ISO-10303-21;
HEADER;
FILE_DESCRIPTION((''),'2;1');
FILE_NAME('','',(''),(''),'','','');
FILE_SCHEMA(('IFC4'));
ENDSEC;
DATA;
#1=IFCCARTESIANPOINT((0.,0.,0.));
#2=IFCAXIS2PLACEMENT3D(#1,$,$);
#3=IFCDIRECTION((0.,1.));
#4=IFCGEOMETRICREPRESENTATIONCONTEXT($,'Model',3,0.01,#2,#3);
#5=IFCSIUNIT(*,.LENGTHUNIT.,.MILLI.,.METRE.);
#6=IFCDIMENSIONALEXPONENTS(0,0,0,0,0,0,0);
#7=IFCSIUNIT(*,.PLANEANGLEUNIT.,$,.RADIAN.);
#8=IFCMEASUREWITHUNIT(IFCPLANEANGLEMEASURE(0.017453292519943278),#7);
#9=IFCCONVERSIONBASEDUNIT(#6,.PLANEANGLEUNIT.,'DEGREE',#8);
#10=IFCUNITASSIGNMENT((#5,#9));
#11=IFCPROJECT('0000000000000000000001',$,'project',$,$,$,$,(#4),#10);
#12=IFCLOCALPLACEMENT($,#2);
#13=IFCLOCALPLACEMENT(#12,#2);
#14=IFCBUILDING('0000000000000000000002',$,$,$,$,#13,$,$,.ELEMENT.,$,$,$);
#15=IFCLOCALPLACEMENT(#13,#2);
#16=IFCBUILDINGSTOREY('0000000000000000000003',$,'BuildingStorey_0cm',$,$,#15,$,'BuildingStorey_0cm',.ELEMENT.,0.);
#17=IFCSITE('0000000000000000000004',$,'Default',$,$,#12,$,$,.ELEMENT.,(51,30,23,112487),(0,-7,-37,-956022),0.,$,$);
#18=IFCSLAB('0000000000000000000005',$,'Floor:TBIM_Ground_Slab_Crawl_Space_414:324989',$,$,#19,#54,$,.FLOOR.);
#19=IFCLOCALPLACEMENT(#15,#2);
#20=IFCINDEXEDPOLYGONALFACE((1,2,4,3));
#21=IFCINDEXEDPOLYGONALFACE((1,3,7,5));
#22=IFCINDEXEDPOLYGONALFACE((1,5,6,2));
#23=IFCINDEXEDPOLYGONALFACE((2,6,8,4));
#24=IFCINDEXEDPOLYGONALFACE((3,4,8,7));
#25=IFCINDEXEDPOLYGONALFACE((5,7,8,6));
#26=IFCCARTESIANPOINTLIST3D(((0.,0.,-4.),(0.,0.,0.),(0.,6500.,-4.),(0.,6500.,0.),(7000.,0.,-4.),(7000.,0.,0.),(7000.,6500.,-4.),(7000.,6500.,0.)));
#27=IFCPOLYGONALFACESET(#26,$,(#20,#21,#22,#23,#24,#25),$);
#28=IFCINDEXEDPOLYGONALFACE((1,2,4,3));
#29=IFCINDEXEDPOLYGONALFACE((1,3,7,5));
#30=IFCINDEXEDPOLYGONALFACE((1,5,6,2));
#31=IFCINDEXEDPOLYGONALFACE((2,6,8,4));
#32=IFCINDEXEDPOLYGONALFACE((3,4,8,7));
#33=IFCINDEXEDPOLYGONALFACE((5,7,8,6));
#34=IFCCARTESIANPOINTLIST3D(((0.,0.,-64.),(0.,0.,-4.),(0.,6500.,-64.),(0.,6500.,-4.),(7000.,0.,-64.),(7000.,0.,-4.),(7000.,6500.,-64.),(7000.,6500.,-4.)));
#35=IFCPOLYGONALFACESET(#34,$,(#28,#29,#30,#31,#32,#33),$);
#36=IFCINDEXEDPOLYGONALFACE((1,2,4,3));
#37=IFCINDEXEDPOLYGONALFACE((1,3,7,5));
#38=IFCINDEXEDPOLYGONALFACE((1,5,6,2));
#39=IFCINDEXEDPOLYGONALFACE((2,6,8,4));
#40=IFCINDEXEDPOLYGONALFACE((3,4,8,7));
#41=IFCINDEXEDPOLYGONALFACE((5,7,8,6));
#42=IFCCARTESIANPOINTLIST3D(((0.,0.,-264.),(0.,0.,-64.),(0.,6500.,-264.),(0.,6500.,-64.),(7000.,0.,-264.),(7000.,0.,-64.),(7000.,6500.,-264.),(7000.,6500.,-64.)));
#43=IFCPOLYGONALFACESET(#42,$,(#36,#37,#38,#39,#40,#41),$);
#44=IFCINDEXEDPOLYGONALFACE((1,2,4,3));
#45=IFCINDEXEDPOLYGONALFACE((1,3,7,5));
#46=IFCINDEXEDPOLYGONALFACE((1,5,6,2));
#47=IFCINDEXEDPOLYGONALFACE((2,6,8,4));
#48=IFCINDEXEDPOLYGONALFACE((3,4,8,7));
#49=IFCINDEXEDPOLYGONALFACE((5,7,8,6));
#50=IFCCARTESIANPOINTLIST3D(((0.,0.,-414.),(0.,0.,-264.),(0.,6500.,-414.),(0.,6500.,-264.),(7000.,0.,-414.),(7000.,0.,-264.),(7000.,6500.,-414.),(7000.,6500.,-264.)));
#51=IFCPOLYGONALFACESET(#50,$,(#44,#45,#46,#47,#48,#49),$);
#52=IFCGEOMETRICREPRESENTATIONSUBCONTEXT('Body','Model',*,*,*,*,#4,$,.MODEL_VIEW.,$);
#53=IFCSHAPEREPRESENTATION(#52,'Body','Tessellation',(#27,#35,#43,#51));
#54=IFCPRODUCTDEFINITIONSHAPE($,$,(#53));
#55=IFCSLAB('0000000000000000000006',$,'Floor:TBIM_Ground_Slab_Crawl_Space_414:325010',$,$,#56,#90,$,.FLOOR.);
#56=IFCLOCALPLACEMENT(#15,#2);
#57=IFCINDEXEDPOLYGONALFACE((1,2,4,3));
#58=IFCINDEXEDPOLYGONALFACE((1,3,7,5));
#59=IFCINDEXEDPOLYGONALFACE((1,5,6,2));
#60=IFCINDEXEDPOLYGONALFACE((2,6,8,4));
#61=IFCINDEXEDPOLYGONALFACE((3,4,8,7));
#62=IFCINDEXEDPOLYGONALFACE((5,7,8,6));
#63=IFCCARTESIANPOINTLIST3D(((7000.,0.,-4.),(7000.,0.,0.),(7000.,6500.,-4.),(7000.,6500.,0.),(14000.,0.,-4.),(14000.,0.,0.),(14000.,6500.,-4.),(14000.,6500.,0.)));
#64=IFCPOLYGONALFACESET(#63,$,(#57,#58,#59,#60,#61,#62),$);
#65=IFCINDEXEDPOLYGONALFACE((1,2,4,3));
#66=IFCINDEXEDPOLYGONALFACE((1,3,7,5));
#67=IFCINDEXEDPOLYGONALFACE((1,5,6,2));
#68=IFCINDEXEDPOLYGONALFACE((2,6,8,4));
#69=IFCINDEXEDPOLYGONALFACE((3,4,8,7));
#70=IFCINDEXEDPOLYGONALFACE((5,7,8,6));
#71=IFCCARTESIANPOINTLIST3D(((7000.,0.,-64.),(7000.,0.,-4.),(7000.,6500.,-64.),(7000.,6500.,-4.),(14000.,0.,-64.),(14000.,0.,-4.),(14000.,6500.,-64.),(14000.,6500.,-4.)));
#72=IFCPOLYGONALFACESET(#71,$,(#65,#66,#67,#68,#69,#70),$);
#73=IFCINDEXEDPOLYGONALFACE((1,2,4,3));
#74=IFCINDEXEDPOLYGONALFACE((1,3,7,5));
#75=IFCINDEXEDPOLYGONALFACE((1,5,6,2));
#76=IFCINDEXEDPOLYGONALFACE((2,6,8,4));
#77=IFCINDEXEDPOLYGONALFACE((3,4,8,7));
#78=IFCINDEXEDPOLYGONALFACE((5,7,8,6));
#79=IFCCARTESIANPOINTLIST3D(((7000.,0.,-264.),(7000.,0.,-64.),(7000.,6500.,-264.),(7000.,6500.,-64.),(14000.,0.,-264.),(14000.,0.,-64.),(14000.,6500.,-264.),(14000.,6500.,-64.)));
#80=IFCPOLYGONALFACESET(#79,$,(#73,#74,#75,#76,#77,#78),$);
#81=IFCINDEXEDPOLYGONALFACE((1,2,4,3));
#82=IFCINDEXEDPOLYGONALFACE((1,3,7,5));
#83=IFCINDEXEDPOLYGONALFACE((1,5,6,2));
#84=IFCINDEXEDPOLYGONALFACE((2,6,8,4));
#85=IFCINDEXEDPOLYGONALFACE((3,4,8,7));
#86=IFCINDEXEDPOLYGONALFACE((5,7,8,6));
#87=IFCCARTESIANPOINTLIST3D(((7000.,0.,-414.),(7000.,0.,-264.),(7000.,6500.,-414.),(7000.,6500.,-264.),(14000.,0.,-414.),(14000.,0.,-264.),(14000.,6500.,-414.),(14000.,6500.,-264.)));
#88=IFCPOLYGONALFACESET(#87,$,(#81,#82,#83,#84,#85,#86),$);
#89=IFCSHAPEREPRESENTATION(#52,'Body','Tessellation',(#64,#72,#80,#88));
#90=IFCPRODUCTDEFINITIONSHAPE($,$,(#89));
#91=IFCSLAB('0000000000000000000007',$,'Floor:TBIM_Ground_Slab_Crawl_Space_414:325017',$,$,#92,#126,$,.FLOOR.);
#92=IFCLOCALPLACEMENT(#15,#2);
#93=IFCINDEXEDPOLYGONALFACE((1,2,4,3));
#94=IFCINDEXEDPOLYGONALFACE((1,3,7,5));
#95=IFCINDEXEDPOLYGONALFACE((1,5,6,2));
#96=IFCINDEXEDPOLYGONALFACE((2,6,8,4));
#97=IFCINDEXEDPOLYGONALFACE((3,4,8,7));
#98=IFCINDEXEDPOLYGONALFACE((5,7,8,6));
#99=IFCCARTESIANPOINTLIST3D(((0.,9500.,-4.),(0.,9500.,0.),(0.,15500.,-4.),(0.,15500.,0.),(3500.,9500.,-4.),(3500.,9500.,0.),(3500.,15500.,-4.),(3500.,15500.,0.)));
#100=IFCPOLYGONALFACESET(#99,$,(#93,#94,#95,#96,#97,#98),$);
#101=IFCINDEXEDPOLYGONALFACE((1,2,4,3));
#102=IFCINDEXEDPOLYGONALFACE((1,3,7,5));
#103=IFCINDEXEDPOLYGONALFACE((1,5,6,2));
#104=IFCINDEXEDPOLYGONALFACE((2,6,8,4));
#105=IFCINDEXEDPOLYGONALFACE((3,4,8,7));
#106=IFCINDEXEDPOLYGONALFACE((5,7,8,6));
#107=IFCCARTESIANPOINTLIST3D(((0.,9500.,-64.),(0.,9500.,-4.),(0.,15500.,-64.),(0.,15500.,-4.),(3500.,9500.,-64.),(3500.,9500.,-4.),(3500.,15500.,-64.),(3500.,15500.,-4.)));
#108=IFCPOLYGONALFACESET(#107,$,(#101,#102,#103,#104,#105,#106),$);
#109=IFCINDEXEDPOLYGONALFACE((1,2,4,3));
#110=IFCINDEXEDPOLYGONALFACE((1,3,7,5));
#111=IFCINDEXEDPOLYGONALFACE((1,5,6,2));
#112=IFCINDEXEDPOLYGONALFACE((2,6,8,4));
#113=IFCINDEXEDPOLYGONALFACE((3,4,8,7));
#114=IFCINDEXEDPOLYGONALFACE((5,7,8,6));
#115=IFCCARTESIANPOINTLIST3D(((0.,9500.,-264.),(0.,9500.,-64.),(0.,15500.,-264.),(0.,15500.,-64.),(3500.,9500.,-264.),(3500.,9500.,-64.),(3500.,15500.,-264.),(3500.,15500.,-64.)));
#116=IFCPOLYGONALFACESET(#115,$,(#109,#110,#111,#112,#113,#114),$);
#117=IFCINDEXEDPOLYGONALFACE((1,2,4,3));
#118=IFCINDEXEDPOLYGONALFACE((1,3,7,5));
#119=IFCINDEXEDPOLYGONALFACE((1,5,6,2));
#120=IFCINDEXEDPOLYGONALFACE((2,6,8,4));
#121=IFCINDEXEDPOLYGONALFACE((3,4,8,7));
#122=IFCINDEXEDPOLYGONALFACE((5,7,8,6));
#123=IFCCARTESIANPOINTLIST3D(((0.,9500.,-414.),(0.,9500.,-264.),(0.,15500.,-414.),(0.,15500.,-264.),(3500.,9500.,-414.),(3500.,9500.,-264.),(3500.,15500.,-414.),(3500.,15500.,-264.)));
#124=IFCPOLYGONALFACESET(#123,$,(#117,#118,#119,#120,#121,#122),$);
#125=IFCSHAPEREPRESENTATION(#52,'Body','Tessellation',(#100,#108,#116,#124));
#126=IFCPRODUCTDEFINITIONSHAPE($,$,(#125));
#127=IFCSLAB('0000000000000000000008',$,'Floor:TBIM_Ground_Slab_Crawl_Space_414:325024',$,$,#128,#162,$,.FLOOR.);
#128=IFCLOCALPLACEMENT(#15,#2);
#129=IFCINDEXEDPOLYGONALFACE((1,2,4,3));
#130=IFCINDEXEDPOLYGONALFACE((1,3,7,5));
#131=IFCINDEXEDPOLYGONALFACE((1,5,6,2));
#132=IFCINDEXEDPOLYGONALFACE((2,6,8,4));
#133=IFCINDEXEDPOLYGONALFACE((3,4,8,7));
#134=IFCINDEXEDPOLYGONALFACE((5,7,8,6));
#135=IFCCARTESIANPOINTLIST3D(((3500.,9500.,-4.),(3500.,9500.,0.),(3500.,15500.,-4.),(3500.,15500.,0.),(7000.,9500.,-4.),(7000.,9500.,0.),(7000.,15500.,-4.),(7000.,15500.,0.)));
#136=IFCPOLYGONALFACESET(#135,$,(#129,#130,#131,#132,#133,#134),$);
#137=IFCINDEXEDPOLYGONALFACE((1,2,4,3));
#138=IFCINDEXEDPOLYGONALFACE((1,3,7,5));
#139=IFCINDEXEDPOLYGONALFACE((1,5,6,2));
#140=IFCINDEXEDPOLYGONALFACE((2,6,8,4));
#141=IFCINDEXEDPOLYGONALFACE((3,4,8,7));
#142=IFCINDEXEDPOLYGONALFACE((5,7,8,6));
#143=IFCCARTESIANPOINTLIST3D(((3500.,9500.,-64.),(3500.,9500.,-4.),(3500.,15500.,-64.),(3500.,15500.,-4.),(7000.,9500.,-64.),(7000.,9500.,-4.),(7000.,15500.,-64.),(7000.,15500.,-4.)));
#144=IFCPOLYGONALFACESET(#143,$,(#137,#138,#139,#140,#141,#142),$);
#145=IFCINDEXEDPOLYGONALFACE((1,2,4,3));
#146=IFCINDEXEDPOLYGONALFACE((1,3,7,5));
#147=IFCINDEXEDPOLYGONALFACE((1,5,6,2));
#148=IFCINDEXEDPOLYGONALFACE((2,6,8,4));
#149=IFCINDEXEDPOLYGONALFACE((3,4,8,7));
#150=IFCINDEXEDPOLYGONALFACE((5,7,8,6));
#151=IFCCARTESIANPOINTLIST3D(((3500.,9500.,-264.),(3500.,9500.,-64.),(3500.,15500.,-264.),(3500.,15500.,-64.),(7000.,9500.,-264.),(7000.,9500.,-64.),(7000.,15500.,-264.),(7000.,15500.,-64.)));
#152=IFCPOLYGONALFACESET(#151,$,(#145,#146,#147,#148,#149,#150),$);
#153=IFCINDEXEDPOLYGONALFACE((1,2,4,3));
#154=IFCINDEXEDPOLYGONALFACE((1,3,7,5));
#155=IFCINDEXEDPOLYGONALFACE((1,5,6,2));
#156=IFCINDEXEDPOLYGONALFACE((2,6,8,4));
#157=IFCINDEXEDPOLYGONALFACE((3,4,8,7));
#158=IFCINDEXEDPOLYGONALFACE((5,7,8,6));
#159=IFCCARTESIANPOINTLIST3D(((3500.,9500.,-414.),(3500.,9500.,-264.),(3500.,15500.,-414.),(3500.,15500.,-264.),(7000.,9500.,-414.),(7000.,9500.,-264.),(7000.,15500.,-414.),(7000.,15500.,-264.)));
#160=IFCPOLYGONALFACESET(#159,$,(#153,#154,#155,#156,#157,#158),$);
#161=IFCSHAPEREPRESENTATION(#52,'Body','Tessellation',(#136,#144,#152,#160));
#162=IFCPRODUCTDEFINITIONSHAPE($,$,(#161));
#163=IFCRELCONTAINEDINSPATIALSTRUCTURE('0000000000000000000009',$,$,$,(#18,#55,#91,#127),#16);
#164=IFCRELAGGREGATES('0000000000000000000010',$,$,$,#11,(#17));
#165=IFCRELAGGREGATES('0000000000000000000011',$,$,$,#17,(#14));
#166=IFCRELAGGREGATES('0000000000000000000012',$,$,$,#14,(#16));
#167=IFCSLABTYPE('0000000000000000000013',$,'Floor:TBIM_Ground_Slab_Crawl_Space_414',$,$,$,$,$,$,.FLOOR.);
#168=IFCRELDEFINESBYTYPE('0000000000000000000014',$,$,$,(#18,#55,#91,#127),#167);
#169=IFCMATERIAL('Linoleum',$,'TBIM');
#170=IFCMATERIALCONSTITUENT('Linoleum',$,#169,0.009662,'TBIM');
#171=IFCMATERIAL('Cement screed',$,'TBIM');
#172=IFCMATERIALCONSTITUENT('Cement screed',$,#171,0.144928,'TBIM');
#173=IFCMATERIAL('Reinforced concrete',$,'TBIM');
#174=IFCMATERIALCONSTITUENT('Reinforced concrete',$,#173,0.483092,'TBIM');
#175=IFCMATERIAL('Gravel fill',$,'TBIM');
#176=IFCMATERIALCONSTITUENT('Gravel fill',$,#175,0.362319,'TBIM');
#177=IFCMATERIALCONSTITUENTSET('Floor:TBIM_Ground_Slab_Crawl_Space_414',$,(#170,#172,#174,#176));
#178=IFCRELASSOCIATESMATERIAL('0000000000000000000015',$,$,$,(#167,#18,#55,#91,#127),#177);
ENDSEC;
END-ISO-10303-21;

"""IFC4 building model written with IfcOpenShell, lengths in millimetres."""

from ifc_helpers import new_model, entity, si_unit, converted_unit, direction, frame, origin, place, context, subcontext, project, spatial, indexed_curve, outline, extrude, material, constituent, constituent_set, type_object, element, save


model = new_model("IFC4")

# Units and contexts
model_context = context("Model", 3, precision=0.01, world=origin(), true_north=direction((0.0, 1.0)))
body_context = subcontext(model_context, "Body", "Model", "MODEL_VIEW")
ifc_project = project(units=[si_unit("LENGTHUNIT", "METRE", prefix="MILLI"), converted_unit("PLANEANGLEUNIT", "DEGREE", entity("IfcPlaneAngleMeasure", 0.017453292519943278), si_unit("PLANEANGLEUNIT", "RADIAN"), dimensions=[0, 0, 0, 0, 0, 0, 0])], contexts=[model_context])

# Site, building, storey
site_placement = place(None, origin())
site = spatial("IfcSite", under=ifc_project, at=site_placement, Name="Default", CompositionType="ELEMENT", RefLatitude=(51, 30, 23, 112487), RefLongitude=(0, -7, -37, -956022), RefElevation=0.0)
building_placement = place(site_placement, origin())
building = spatial("IfcBuilding", under=site, at=building_placement, CompositionType="ELEMENT")
storey_placement = place(building_placement, origin())
storey = spatial("IfcBuildingStorey", under=building, at=storey_placement, Name="BuildingStorey_0cm", LongName="BuildingStorey_0cm", CompositionType="ELEMENT", Elevation=0.0)

# Slabs
ifc_material_1 = material(Name="Linoleum", Category="TBIM")
ifc_constituent_1 = constituent(ifc_material_1, Name="Linoleum", Category="TBIM", fraction=0.009662)
ifc_material_2 = material(Name="Cement screed", Category="TBIM")
ifc_constituent_2 = constituent(ifc_material_2, Name="Cement screed", Category="TBIM", fraction=0.144928)
ifc_material_3 = material(Name="Reinforced concrete", Category="TBIM")
ifc_constituent_3 = constituent(ifc_material_3, Name="Reinforced concrete", Category="TBIM", fraction=0.483092)
ifc_material_4 = material(Name="Gravel fill", Category="TBIM")
ifc_constituent_4 = constituent(ifc_material_4, Name="Gravel fill", Category="TBIM", fraction=0.362319)
ifc_constituent_set_1 = constituent_set(constituents=[ifc_constituent_1, ifc_constituent_2, ifc_constituent_3, ifc_constituent_4], Name="Floor:TBIM_Ground_Slab_Crawl_Space_414")
slab_type = type_object("IfcSlabType", Name="Floor:TBIM_Ground_Slab_Crawl_Space_414", PredefinedType="FLOOR", material=ifc_constituent_set_1)
slab_1_placement = place(storey_placement, origin())
element("IfcSlab", 1, at=slab_1_placement, inside=storey, type_object=slab_type, material=ifc_constituent_set_1, Name="Floor:TBIM_Ground_Slab_Crawl_Space_414:324989", PredefinedType="FLOOR", context=body_context, shape_type="SweptSolid", body=[
    extrude(outline(indexed_curve([(-3500.0, -3250.0), (3500.0, -3250.0), (3500.0, 3250.0), (-3500.0, 3250.0), (-3500.0, -3250.0)], self_intersect=False)), frame((3500.0, 3250.0, -4.0), z_axis=(0.0, 0.0, 1.0), x_axis=(-1.0, 0.0, 0.0)), (0.0, 0.0, 1.0), 4.0),
    extrude(outline(indexed_curve([(-3500.0, -3250.0), (3500.0, -3250.0), (3500.0, 3250.0), (-3500.0, 3250.0), (-3500.0, -3250.0)], self_intersect=False)), frame((3500.0, 3250.0, -64.0), z_axis=(0.0, 0.0, 1.0), x_axis=(-1.0, 0.0, 0.0)), (0.0, 0.0, 1.0), 60.0),
    extrude(outline(indexed_curve([(-3500.0, -3250.0), (3500.0, -3250.0), (3500.0, 3250.0), (-3500.0, 3250.0), (-3500.0, -3250.0)], self_intersect=False)), frame((3500.0, 3250.0, -264.0), z_axis=(0.0, 0.0, 1.0), x_axis=(-1.0, 0.0, 0.0)), (0.0, 0.0, 1.0), 200.0),
    extrude(outline(indexed_curve([(-3500.0, -3250.0), (3500.0, -3250.0), (3500.0, 3250.0), (-3500.0, 3250.0), (-3500.0, -3250.0)], self_intersect=False)), frame((3500.0, 3250.0, -414.0), z_axis=(0.0, 0.0, 1.0), x_axis=(-1.0, 0.0, 0.0)), (0.0, 0.0, 1.0), 150.0),
])
slab_2_placement = place(storey_placement, origin())
element("IfcSlab", 2, at=slab_2_placement, inside=storey, type_object=slab_type, material=ifc_constituent_set_1, Name="Floor:TBIM_Ground_Slab_Crawl_Space_414:325010", PredefinedType="FLOOR", context=body_context, shape_type="SweptSolid", body=[
    extrude(outline(indexed_curve([(-3500.0, -3250.0), (3500.0, -3250.0), (3500.0, 3250.0), (-3500.0, 3250.0), (-3500.0, -3250.0)], self_intersect=False)), frame((10500.0, 3250.0, -4.0), z_axis=(0.0, 0.0, 1.0), x_axis=(-1.0, 0.0, 0.0)), (0.0, 0.0, 1.0), 4.0),
    extrude(outline(indexed_curve([(-3500.0, -3250.0), (3500.0, -3250.0), (3500.0, 3250.0), (-3500.0, 3250.0), (-3500.0, -3250.0)], self_intersect=False)), frame((10500.0, 3250.0, -64.0), z_axis=(0.0, 0.0, 1.0), x_axis=(-1.0, 0.0, 0.0)), (0.0, 0.0, 1.0), 60.0),
    extrude(outline(indexed_curve([(-3500.0, -3250.0), (3500.0, -3250.0), (3500.0, 3250.0), (-3500.0, 3250.0), (-3500.0, -3250.0)], self_intersect=False)), frame((10500.0, 3250.0, -264.0), z_axis=(0.0, 0.0, 1.0), x_axis=(-1.0, 0.0, 0.0)), (0.0, 0.0, 1.0), 200.0),
    extrude(outline(indexed_curve([(-3500.0, -3250.0), (3500.0, -3250.0), (3500.0, 3250.0), (-3500.0, 3250.0), (-3500.0, -3250.0)], self_intersect=False)), frame((10500.0, 3250.0, -414.0), z_axis=(0.0, 0.0, 1.0), x_axis=(-1.0, 0.0, 0.0)), (0.0, 0.0, 1.0), 150.0),
])
slab_3_placement = place(storey_placement, origin())
element("IfcSlab", 3, at=slab_3_placement, inside=storey, type_object=slab_type, material=ifc_constituent_set_1, Name="Floor:TBIM_Ground_Slab_Crawl_Space_414:325017", PredefinedType="FLOOR", context=body_context, shape_type="SweptSolid", body=[
    extrude(outline(indexed_curve([(-1750.0, -3000.0), (1750.0, -3000.0), (1750.0, 3000.0), (-1750.0, 3000.0), (-1750.0, -3000.0)], self_intersect=False)), frame((1750.0, 12500.0, -4.0), z_axis=(0.0, 0.0, 1.0), x_axis=(-1.0, 0.0, 0.0)), (0.0, 0.0, 1.0), 4.0),
    extrude(outline(indexed_curve([(-1750.0, -3000.0), (1750.0, -3000.0), (1750.0, 3000.0), (-1750.0, 3000.0), (-1750.0, -3000.0)], self_intersect=False)), frame((1750.0, 12500.0, -64.0), z_axis=(0.0, 0.0, 1.0), x_axis=(-1.0, 0.0, 0.0)), (0.0, 0.0, 1.0), 60.0),
    extrude(outline(indexed_curve([(-1750.0, -3000.0), (1750.0, -3000.0), (1750.0, 3000.0), (-1750.0, 3000.0), (-1750.0, -3000.0)], self_intersect=False)), frame((1750.0, 12500.0, -264.0), z_axis=(0.0, 0.0, 1.0), x_axis=(-1.0, 0.0, 0.0)), (0.0, 0.0, 1.0), 200.0),
    extrude(outline(indexed_curve([(-1750.0, -3000.0), (1750.0, -3000.0), (1750.0, 3000.0), (-1750.0, 3000.0), (-1750.0, -3000.0)], self_intersect=False)), frame((1750.0, 12500.0, -414.0), z_axis=(0.0, 0.0, 1.0), x_axis=(-1.0, 0.0, 0.0)), (0.0, 0.0, 1.0), 150.0),
])
slab_4_placement = place(storey_placement, origin())
element("IfcSlab", 4, at=slab_4_placement, inside=storey, type_object=slab_type, material=ifc_constituent_set_1, Name="Floor:TBIM_Ground_Slab_Crawl_Space_414:325024", PredefinedType="FLOOR", context=body_context, shape_type="SweptSolid", body=[
    extrude(outline(indexed_curve([(-1750.0, -3000.0), (1750.0, -3000.0), (1750.0, 3000.0), (-1750.0, 3000.0), (-1750.0, -3000.0)], self_intersect=False)), frame((5250.0, 12500.0, -4.0), z_axis=(0.0, 0.0, 1.0), x_axis=(-1.0, 0.0, 0.0)), (0.0, 0.0, 1.0), 4.0),
    extrude(outline(indexed_curve([(-1750.0, -3000.0), (1750.0, -3000.0), (1750.0, 3000.0), (-1750.0, 3000.0), (-1750.0, -3000.0)], self_intersect=False)), frame((5250.0, 12500.0, -64.0), z_axis=(0.0, 0.0, 1.0), x_axis=(-1.0, 0.0, 0.0)), (0.0, 0.0, 1.0), 60.0),
    extrude(outline(indexed_curve([(-1750.0, -3000.0), (1750.0, -3000.0), (1750.0, 3000.0), (-1750.0, 3000.0), (-1750.0, -3000.0)], self_intersect=False)), frame((5250.0, 12500.0, -264.0), z_axis=(0.0, 0.0, 1.0), x_axis=(-1.0, 0.0, 0.0)), (0.0, 0.0, 1.0), 200.0),
    extrude(outline(indexed_curve([(-1750.0, -3000.0), (1750.0, -3000.0), (1750.0, 3000.0), (-1750.0, 3000.0), (-1750.0, -3000.0)], self_intersect=False)), frame((5250.0, 12500.0, -414.0), z_axis=(0.0, 0.0, 1.0), x_axis=(-1.0, 0.0, 0.0)), (0.0, 0.0, 1.0), 150.0),
])

save(model, "model.ifc")
